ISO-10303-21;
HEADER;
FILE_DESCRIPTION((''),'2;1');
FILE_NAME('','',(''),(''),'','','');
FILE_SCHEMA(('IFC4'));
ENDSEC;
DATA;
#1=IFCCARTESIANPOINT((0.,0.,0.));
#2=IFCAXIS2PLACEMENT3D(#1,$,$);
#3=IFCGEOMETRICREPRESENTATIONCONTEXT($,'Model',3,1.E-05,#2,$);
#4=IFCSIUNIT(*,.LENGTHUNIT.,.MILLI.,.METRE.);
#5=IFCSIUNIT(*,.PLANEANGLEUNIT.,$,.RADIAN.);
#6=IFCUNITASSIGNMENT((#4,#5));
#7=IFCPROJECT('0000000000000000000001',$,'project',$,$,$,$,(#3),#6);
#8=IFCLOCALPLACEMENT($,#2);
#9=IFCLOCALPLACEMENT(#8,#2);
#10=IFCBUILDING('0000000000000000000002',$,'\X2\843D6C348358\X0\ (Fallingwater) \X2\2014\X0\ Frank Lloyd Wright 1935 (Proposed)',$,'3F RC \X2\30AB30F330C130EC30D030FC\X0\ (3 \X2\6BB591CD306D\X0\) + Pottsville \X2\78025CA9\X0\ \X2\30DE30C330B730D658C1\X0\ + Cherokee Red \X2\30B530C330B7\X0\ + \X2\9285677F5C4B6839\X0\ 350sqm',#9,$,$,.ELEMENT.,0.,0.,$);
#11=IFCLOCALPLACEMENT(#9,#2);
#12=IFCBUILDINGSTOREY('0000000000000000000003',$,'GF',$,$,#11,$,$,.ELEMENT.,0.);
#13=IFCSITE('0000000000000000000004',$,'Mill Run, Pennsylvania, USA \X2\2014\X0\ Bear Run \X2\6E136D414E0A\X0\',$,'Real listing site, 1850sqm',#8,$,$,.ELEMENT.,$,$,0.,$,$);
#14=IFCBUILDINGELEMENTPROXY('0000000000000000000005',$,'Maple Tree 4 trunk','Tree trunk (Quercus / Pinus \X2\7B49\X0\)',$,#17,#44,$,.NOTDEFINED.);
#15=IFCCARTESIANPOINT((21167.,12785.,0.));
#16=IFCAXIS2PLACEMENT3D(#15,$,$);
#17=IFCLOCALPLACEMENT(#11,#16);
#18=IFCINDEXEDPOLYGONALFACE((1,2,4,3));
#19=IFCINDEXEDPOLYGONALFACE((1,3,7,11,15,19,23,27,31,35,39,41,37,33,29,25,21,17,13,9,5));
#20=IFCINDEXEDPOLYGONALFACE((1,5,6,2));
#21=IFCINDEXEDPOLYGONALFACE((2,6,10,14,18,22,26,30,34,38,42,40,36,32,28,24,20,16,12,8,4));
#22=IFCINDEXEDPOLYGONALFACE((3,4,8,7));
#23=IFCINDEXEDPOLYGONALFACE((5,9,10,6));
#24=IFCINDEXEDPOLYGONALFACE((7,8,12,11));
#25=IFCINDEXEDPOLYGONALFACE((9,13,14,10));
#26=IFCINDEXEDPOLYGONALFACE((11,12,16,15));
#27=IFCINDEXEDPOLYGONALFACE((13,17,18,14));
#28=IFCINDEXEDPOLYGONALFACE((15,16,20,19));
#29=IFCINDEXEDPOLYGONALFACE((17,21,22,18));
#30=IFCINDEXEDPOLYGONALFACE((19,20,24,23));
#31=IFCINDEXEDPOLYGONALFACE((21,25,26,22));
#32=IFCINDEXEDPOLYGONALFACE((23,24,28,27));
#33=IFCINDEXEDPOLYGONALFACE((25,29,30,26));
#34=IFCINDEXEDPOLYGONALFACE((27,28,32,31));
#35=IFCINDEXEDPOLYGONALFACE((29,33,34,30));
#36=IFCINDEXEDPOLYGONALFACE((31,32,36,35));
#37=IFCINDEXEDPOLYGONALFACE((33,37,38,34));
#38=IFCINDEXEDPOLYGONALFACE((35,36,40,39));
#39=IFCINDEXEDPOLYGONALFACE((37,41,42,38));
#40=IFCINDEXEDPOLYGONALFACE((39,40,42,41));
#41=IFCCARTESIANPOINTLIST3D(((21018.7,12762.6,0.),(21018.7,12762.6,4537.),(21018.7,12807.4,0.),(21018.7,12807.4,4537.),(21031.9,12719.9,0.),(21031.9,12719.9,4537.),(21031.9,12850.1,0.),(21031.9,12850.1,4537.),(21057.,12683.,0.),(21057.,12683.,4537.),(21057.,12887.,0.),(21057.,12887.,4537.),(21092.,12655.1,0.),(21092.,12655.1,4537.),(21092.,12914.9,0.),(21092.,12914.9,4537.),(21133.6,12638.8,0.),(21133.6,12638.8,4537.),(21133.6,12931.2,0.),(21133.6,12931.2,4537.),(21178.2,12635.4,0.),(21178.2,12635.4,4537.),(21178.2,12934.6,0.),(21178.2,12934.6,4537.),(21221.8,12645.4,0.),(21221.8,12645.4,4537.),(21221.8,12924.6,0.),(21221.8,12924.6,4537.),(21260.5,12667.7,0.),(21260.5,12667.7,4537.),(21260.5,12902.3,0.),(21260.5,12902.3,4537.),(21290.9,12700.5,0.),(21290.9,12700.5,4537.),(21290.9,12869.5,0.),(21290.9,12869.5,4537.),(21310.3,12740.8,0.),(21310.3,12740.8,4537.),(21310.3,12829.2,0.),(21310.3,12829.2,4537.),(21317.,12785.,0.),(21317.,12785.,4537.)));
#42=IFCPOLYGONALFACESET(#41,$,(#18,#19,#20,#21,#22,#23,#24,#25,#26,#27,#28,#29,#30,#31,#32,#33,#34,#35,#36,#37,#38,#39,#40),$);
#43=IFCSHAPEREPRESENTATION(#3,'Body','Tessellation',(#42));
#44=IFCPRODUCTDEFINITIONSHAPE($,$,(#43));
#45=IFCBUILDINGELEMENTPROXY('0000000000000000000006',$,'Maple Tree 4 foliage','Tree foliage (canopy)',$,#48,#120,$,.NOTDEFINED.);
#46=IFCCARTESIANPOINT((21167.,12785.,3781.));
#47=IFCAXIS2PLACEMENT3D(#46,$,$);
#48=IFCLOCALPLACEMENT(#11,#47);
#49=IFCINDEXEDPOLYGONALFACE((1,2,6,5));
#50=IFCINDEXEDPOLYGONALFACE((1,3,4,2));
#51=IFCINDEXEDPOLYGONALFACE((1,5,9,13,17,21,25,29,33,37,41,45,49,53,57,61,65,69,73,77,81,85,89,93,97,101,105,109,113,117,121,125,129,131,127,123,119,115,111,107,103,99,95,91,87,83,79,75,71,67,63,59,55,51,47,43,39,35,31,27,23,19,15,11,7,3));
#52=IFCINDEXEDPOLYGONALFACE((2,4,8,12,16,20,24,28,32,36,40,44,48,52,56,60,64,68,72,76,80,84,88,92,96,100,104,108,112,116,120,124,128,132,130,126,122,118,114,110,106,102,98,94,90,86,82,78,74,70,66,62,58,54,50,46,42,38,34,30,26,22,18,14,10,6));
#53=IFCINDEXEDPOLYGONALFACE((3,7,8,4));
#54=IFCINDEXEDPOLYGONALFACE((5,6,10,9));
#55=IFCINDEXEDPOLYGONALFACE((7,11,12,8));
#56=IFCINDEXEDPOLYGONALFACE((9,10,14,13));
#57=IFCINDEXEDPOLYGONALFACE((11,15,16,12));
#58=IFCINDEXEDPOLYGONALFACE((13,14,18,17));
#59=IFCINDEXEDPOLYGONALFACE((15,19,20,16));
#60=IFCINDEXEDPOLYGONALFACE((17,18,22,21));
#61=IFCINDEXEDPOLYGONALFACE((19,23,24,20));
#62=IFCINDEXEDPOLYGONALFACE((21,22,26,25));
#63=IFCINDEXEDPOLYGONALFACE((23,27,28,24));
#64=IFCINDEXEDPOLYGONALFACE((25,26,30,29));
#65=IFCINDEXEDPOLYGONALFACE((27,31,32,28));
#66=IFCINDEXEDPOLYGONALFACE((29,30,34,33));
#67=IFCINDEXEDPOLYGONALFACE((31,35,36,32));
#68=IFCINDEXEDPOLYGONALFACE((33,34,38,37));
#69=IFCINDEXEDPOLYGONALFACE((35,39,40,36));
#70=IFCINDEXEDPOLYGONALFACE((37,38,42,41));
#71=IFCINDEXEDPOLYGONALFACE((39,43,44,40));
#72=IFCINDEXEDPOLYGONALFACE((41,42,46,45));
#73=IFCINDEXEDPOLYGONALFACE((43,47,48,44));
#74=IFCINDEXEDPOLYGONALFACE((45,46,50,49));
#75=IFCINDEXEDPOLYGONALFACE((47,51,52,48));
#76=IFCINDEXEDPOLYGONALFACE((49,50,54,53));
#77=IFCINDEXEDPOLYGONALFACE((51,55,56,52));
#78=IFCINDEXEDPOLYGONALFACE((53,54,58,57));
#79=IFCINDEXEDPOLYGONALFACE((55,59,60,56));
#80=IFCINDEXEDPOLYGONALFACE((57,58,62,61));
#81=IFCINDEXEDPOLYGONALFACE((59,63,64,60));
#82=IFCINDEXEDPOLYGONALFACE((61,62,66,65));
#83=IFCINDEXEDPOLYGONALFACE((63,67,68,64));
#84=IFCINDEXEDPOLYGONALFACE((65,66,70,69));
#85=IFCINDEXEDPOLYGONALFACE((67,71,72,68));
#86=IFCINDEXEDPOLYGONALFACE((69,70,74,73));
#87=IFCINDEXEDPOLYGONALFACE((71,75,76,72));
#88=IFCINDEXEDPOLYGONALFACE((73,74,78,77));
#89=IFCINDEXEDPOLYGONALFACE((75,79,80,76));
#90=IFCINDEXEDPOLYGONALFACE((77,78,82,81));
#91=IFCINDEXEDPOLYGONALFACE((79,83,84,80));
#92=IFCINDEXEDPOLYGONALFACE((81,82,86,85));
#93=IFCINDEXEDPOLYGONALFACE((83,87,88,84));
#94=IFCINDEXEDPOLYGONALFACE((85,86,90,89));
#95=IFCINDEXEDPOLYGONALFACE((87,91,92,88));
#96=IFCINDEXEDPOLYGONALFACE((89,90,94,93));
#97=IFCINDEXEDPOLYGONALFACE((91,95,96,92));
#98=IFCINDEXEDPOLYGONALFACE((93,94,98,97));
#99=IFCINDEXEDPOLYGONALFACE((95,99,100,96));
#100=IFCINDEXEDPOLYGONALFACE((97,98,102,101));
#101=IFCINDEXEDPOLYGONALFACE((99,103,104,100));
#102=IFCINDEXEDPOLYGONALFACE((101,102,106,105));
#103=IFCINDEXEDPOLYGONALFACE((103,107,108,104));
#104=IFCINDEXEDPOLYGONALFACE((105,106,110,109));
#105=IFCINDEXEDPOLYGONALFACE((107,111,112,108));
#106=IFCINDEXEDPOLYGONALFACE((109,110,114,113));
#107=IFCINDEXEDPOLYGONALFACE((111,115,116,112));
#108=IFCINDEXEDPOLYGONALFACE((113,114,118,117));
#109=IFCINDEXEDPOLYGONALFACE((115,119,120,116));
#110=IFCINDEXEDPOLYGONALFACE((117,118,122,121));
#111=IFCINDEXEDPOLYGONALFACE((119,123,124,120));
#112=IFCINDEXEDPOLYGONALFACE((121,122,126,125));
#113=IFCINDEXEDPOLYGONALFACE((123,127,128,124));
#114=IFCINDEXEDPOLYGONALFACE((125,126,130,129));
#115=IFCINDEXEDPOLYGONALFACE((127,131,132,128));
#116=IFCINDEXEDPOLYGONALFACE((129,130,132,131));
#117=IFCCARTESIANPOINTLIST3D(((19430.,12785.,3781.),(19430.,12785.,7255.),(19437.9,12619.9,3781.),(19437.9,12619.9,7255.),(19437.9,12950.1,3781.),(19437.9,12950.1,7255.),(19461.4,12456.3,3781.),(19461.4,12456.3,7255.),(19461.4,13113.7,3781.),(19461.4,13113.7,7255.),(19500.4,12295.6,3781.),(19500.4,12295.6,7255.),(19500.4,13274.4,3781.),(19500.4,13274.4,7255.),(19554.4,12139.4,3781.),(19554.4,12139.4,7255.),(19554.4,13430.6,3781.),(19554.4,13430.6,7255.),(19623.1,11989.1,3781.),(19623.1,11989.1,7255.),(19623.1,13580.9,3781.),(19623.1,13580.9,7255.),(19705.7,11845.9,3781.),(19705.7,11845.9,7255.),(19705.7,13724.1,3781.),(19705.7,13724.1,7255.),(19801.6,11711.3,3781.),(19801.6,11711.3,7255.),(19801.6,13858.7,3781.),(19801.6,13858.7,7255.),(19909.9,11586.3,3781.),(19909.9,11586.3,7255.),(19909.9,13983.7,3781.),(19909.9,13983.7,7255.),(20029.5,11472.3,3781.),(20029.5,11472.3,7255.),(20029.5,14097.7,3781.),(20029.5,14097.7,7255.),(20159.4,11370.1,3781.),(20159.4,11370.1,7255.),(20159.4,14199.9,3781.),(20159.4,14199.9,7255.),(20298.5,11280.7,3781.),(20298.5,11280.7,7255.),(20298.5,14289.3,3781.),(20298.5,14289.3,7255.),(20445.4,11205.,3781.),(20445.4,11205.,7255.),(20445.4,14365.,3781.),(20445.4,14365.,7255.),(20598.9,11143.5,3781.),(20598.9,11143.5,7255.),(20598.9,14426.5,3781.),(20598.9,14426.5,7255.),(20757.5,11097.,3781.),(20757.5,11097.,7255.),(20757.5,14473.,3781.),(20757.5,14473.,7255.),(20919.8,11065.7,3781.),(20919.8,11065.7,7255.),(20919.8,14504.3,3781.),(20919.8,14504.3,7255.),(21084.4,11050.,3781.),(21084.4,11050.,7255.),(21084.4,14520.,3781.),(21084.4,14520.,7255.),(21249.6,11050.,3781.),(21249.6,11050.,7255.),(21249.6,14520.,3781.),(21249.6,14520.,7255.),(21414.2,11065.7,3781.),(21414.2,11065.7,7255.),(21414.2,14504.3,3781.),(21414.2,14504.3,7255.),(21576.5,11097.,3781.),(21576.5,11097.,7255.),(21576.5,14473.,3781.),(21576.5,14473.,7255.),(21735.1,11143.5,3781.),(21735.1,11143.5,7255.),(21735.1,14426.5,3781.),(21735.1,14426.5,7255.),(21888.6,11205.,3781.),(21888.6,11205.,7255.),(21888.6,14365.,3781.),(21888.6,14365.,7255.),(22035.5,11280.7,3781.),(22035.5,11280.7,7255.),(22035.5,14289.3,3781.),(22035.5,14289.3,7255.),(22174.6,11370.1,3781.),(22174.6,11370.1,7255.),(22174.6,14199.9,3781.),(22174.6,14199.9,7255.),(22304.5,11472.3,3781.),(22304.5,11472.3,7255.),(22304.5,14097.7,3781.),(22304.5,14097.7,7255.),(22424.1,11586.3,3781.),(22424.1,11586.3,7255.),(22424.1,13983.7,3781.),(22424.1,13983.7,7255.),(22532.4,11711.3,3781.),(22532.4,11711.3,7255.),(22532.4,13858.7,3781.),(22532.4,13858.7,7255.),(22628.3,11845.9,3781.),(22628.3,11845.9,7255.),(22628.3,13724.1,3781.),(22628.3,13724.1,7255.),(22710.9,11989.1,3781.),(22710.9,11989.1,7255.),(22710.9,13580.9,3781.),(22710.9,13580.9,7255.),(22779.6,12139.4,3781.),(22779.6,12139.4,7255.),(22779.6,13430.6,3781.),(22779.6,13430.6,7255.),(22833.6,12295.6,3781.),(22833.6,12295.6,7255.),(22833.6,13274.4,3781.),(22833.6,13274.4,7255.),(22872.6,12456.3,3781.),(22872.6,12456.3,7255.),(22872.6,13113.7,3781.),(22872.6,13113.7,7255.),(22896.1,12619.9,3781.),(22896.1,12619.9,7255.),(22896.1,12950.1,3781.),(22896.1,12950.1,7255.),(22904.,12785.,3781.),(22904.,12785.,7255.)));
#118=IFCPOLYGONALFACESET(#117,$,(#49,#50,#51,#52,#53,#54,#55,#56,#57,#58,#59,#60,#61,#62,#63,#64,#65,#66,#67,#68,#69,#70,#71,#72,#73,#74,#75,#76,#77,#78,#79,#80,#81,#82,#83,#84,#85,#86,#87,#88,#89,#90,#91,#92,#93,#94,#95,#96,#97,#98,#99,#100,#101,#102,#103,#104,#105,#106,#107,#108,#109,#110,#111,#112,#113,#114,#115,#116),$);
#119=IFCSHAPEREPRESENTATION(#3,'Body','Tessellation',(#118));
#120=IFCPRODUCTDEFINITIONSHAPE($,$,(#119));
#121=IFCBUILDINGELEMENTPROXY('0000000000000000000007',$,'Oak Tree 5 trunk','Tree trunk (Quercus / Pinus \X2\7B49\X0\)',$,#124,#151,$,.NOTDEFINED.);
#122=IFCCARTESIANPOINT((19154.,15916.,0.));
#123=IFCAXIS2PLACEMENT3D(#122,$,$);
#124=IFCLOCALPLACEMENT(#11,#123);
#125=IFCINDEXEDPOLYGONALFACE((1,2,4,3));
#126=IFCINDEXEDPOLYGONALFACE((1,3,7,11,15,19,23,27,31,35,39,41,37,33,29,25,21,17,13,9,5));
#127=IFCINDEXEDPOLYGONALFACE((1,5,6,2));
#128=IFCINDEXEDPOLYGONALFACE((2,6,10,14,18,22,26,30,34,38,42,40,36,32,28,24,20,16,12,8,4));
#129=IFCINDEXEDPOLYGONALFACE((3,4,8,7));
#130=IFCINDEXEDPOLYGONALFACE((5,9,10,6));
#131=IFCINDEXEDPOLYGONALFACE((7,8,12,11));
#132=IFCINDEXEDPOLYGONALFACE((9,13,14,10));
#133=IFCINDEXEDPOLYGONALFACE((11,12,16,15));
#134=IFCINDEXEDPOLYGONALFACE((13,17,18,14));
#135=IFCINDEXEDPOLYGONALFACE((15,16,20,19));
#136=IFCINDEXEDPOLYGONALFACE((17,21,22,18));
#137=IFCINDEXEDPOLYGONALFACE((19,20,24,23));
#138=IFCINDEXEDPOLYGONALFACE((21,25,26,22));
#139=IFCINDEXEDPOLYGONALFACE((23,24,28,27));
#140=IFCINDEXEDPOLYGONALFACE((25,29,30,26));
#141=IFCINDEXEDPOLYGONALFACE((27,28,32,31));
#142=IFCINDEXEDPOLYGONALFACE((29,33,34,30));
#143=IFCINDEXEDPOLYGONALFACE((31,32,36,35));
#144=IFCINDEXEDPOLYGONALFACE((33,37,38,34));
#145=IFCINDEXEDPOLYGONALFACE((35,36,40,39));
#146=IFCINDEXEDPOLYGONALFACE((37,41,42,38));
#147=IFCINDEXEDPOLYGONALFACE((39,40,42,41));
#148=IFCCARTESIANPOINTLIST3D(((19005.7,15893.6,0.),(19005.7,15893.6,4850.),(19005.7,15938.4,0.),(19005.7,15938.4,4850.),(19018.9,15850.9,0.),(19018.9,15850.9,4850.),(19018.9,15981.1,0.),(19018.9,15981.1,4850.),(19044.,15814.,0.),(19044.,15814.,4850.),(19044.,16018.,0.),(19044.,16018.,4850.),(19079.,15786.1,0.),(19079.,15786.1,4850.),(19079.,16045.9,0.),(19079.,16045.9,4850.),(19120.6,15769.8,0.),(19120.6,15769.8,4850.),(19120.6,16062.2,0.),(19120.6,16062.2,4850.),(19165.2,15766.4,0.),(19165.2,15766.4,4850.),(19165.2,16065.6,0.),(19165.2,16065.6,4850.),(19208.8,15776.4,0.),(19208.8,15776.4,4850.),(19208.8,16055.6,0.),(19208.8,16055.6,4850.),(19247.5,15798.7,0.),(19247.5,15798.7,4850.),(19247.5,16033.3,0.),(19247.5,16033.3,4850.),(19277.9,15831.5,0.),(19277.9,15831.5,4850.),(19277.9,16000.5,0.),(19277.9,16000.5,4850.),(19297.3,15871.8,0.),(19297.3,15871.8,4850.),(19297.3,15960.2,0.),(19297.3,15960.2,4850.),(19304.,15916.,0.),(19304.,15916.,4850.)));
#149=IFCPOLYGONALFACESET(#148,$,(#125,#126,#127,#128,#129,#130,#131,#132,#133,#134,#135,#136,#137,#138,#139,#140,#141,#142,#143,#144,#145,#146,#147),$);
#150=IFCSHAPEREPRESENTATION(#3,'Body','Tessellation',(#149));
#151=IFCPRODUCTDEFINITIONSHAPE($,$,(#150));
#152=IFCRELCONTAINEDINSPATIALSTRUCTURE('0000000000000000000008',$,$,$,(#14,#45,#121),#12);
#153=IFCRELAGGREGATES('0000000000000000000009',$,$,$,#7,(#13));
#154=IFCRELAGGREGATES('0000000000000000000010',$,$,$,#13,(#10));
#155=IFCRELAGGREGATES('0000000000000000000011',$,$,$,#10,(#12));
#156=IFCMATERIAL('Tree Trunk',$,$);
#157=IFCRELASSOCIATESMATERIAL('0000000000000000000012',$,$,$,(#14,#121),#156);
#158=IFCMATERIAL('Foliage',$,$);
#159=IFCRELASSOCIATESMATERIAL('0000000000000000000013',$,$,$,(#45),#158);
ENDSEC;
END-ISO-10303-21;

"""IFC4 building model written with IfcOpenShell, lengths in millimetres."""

from ifc_helpers import new_model, si_unit, frame, origin, origin_2d, place, context, project, spatial, circle, extrude, material, element, save


model = new_model("IFC4")

# Units and contexts
model_context = context("Model", 3, precision=1e-05, world=origin())
ifc_project = project(units=[si_unit("LENGTHUNIT", "METRE", prefix="MILLI"), si_unit("PLANEANGLEUNIT", "RADIAN")], contexts=[model_context])

# Site, building, storey
site_placement = place(None, origin())
site = spatial("IfcSite", under=ifc_project, at=site_placement, Name="Mill Run, Pennsylvania, USA — Bear Run 渓流上", ObjectType="Real listing site, 1850sqm", CompositionType="ELEMENT", RefElevation=0.0)
building_placement = place(site_placement, origin())
building = spatial("IfcBuilding", under=site, at=building_placement, Name="落水荘 (Fallingwater) — Frank Lloyd Wright 1935 (Proposed)", ObjectType="3F RC カンチレバー (3 段重ね) + Pottsville 砂岩 マッシブ壁 + Cherokee Red サッシ + 銅板屋根 350sqm", CompositionType="ELEMENT", ElevationOfRefHeight=0.0, ElevationOfTerrain=0.0)
storey_placement = place(building_placement, origin())
storey = spatial("IfcBuildingStorey", under=building, at=storey_placement, Name="GF", CompositionType="ELEMENT", Elevation=0.0)

# Building element proxies
ifc_material_1 = material(Name="Tree Trunk")
ifc_material_2 = material(Name="Foliage")
proxy_1_placement = place(storey_placement, frame((21167.0, 12785.0, 0.0)))
element("IfcBuildingElementProxy", 1, at=proxy_1_placement, inside=storey, material=ifc_material_1, Name="Maple Tree 4 trunk", Description="Tree trunk (Quercus / Pinus 等)", PredefinedType="NOTDEFINED", context=model_context, shape_type="SweptSolid", body=[
    extrude(circle(Radius=150.0, at=origin_2d()), frame((21167.0, 12785.0, 0.0)), (0.0, 0.0, 1.0), 4537.0),
])
proxy_2_placement = place(storey_placement, frame((21167.0, 12785.0, 3781.0)))
element("IfcBuildingElementProxy", 2, at=proxy_2_placement, inside=storey, material=ifc_material_2, Name="Maple Tree 4 foliage", Description="Tree foliage (canopy)", PredefinedType="NOTDEFINED", context=model_context, shape_type="SweptSolid", body=[
    extrude(circle(Radius=1737.0, at=origin_2d()), frame((21167.0, 12785.0, 3781.0)), (0.0, 0.0, 1.0), 3474.0),
])
proxy_3_placement = place(storey_placement, frame((19154.0, 15916.0, 0.0)))
element("IfcBuildingElementProxy", 3, at=proxy_3_placement, inside=storey, material=ifc_material_1, Name="Oak Tree 5 trunk", Description="Tree trunk (Quercus / Pinus 等)", PredefinedType="NOTDEFINED", context=model_context, shape_type="SweptSolid", body=[
    extrude(circle(Radius=150.0, at=origin_2d()), frame((19154.0, 15916.0, 0.0)), (0.0, 0.0, 1.0), 4850.0),
])

save(model, "model.ifc")
